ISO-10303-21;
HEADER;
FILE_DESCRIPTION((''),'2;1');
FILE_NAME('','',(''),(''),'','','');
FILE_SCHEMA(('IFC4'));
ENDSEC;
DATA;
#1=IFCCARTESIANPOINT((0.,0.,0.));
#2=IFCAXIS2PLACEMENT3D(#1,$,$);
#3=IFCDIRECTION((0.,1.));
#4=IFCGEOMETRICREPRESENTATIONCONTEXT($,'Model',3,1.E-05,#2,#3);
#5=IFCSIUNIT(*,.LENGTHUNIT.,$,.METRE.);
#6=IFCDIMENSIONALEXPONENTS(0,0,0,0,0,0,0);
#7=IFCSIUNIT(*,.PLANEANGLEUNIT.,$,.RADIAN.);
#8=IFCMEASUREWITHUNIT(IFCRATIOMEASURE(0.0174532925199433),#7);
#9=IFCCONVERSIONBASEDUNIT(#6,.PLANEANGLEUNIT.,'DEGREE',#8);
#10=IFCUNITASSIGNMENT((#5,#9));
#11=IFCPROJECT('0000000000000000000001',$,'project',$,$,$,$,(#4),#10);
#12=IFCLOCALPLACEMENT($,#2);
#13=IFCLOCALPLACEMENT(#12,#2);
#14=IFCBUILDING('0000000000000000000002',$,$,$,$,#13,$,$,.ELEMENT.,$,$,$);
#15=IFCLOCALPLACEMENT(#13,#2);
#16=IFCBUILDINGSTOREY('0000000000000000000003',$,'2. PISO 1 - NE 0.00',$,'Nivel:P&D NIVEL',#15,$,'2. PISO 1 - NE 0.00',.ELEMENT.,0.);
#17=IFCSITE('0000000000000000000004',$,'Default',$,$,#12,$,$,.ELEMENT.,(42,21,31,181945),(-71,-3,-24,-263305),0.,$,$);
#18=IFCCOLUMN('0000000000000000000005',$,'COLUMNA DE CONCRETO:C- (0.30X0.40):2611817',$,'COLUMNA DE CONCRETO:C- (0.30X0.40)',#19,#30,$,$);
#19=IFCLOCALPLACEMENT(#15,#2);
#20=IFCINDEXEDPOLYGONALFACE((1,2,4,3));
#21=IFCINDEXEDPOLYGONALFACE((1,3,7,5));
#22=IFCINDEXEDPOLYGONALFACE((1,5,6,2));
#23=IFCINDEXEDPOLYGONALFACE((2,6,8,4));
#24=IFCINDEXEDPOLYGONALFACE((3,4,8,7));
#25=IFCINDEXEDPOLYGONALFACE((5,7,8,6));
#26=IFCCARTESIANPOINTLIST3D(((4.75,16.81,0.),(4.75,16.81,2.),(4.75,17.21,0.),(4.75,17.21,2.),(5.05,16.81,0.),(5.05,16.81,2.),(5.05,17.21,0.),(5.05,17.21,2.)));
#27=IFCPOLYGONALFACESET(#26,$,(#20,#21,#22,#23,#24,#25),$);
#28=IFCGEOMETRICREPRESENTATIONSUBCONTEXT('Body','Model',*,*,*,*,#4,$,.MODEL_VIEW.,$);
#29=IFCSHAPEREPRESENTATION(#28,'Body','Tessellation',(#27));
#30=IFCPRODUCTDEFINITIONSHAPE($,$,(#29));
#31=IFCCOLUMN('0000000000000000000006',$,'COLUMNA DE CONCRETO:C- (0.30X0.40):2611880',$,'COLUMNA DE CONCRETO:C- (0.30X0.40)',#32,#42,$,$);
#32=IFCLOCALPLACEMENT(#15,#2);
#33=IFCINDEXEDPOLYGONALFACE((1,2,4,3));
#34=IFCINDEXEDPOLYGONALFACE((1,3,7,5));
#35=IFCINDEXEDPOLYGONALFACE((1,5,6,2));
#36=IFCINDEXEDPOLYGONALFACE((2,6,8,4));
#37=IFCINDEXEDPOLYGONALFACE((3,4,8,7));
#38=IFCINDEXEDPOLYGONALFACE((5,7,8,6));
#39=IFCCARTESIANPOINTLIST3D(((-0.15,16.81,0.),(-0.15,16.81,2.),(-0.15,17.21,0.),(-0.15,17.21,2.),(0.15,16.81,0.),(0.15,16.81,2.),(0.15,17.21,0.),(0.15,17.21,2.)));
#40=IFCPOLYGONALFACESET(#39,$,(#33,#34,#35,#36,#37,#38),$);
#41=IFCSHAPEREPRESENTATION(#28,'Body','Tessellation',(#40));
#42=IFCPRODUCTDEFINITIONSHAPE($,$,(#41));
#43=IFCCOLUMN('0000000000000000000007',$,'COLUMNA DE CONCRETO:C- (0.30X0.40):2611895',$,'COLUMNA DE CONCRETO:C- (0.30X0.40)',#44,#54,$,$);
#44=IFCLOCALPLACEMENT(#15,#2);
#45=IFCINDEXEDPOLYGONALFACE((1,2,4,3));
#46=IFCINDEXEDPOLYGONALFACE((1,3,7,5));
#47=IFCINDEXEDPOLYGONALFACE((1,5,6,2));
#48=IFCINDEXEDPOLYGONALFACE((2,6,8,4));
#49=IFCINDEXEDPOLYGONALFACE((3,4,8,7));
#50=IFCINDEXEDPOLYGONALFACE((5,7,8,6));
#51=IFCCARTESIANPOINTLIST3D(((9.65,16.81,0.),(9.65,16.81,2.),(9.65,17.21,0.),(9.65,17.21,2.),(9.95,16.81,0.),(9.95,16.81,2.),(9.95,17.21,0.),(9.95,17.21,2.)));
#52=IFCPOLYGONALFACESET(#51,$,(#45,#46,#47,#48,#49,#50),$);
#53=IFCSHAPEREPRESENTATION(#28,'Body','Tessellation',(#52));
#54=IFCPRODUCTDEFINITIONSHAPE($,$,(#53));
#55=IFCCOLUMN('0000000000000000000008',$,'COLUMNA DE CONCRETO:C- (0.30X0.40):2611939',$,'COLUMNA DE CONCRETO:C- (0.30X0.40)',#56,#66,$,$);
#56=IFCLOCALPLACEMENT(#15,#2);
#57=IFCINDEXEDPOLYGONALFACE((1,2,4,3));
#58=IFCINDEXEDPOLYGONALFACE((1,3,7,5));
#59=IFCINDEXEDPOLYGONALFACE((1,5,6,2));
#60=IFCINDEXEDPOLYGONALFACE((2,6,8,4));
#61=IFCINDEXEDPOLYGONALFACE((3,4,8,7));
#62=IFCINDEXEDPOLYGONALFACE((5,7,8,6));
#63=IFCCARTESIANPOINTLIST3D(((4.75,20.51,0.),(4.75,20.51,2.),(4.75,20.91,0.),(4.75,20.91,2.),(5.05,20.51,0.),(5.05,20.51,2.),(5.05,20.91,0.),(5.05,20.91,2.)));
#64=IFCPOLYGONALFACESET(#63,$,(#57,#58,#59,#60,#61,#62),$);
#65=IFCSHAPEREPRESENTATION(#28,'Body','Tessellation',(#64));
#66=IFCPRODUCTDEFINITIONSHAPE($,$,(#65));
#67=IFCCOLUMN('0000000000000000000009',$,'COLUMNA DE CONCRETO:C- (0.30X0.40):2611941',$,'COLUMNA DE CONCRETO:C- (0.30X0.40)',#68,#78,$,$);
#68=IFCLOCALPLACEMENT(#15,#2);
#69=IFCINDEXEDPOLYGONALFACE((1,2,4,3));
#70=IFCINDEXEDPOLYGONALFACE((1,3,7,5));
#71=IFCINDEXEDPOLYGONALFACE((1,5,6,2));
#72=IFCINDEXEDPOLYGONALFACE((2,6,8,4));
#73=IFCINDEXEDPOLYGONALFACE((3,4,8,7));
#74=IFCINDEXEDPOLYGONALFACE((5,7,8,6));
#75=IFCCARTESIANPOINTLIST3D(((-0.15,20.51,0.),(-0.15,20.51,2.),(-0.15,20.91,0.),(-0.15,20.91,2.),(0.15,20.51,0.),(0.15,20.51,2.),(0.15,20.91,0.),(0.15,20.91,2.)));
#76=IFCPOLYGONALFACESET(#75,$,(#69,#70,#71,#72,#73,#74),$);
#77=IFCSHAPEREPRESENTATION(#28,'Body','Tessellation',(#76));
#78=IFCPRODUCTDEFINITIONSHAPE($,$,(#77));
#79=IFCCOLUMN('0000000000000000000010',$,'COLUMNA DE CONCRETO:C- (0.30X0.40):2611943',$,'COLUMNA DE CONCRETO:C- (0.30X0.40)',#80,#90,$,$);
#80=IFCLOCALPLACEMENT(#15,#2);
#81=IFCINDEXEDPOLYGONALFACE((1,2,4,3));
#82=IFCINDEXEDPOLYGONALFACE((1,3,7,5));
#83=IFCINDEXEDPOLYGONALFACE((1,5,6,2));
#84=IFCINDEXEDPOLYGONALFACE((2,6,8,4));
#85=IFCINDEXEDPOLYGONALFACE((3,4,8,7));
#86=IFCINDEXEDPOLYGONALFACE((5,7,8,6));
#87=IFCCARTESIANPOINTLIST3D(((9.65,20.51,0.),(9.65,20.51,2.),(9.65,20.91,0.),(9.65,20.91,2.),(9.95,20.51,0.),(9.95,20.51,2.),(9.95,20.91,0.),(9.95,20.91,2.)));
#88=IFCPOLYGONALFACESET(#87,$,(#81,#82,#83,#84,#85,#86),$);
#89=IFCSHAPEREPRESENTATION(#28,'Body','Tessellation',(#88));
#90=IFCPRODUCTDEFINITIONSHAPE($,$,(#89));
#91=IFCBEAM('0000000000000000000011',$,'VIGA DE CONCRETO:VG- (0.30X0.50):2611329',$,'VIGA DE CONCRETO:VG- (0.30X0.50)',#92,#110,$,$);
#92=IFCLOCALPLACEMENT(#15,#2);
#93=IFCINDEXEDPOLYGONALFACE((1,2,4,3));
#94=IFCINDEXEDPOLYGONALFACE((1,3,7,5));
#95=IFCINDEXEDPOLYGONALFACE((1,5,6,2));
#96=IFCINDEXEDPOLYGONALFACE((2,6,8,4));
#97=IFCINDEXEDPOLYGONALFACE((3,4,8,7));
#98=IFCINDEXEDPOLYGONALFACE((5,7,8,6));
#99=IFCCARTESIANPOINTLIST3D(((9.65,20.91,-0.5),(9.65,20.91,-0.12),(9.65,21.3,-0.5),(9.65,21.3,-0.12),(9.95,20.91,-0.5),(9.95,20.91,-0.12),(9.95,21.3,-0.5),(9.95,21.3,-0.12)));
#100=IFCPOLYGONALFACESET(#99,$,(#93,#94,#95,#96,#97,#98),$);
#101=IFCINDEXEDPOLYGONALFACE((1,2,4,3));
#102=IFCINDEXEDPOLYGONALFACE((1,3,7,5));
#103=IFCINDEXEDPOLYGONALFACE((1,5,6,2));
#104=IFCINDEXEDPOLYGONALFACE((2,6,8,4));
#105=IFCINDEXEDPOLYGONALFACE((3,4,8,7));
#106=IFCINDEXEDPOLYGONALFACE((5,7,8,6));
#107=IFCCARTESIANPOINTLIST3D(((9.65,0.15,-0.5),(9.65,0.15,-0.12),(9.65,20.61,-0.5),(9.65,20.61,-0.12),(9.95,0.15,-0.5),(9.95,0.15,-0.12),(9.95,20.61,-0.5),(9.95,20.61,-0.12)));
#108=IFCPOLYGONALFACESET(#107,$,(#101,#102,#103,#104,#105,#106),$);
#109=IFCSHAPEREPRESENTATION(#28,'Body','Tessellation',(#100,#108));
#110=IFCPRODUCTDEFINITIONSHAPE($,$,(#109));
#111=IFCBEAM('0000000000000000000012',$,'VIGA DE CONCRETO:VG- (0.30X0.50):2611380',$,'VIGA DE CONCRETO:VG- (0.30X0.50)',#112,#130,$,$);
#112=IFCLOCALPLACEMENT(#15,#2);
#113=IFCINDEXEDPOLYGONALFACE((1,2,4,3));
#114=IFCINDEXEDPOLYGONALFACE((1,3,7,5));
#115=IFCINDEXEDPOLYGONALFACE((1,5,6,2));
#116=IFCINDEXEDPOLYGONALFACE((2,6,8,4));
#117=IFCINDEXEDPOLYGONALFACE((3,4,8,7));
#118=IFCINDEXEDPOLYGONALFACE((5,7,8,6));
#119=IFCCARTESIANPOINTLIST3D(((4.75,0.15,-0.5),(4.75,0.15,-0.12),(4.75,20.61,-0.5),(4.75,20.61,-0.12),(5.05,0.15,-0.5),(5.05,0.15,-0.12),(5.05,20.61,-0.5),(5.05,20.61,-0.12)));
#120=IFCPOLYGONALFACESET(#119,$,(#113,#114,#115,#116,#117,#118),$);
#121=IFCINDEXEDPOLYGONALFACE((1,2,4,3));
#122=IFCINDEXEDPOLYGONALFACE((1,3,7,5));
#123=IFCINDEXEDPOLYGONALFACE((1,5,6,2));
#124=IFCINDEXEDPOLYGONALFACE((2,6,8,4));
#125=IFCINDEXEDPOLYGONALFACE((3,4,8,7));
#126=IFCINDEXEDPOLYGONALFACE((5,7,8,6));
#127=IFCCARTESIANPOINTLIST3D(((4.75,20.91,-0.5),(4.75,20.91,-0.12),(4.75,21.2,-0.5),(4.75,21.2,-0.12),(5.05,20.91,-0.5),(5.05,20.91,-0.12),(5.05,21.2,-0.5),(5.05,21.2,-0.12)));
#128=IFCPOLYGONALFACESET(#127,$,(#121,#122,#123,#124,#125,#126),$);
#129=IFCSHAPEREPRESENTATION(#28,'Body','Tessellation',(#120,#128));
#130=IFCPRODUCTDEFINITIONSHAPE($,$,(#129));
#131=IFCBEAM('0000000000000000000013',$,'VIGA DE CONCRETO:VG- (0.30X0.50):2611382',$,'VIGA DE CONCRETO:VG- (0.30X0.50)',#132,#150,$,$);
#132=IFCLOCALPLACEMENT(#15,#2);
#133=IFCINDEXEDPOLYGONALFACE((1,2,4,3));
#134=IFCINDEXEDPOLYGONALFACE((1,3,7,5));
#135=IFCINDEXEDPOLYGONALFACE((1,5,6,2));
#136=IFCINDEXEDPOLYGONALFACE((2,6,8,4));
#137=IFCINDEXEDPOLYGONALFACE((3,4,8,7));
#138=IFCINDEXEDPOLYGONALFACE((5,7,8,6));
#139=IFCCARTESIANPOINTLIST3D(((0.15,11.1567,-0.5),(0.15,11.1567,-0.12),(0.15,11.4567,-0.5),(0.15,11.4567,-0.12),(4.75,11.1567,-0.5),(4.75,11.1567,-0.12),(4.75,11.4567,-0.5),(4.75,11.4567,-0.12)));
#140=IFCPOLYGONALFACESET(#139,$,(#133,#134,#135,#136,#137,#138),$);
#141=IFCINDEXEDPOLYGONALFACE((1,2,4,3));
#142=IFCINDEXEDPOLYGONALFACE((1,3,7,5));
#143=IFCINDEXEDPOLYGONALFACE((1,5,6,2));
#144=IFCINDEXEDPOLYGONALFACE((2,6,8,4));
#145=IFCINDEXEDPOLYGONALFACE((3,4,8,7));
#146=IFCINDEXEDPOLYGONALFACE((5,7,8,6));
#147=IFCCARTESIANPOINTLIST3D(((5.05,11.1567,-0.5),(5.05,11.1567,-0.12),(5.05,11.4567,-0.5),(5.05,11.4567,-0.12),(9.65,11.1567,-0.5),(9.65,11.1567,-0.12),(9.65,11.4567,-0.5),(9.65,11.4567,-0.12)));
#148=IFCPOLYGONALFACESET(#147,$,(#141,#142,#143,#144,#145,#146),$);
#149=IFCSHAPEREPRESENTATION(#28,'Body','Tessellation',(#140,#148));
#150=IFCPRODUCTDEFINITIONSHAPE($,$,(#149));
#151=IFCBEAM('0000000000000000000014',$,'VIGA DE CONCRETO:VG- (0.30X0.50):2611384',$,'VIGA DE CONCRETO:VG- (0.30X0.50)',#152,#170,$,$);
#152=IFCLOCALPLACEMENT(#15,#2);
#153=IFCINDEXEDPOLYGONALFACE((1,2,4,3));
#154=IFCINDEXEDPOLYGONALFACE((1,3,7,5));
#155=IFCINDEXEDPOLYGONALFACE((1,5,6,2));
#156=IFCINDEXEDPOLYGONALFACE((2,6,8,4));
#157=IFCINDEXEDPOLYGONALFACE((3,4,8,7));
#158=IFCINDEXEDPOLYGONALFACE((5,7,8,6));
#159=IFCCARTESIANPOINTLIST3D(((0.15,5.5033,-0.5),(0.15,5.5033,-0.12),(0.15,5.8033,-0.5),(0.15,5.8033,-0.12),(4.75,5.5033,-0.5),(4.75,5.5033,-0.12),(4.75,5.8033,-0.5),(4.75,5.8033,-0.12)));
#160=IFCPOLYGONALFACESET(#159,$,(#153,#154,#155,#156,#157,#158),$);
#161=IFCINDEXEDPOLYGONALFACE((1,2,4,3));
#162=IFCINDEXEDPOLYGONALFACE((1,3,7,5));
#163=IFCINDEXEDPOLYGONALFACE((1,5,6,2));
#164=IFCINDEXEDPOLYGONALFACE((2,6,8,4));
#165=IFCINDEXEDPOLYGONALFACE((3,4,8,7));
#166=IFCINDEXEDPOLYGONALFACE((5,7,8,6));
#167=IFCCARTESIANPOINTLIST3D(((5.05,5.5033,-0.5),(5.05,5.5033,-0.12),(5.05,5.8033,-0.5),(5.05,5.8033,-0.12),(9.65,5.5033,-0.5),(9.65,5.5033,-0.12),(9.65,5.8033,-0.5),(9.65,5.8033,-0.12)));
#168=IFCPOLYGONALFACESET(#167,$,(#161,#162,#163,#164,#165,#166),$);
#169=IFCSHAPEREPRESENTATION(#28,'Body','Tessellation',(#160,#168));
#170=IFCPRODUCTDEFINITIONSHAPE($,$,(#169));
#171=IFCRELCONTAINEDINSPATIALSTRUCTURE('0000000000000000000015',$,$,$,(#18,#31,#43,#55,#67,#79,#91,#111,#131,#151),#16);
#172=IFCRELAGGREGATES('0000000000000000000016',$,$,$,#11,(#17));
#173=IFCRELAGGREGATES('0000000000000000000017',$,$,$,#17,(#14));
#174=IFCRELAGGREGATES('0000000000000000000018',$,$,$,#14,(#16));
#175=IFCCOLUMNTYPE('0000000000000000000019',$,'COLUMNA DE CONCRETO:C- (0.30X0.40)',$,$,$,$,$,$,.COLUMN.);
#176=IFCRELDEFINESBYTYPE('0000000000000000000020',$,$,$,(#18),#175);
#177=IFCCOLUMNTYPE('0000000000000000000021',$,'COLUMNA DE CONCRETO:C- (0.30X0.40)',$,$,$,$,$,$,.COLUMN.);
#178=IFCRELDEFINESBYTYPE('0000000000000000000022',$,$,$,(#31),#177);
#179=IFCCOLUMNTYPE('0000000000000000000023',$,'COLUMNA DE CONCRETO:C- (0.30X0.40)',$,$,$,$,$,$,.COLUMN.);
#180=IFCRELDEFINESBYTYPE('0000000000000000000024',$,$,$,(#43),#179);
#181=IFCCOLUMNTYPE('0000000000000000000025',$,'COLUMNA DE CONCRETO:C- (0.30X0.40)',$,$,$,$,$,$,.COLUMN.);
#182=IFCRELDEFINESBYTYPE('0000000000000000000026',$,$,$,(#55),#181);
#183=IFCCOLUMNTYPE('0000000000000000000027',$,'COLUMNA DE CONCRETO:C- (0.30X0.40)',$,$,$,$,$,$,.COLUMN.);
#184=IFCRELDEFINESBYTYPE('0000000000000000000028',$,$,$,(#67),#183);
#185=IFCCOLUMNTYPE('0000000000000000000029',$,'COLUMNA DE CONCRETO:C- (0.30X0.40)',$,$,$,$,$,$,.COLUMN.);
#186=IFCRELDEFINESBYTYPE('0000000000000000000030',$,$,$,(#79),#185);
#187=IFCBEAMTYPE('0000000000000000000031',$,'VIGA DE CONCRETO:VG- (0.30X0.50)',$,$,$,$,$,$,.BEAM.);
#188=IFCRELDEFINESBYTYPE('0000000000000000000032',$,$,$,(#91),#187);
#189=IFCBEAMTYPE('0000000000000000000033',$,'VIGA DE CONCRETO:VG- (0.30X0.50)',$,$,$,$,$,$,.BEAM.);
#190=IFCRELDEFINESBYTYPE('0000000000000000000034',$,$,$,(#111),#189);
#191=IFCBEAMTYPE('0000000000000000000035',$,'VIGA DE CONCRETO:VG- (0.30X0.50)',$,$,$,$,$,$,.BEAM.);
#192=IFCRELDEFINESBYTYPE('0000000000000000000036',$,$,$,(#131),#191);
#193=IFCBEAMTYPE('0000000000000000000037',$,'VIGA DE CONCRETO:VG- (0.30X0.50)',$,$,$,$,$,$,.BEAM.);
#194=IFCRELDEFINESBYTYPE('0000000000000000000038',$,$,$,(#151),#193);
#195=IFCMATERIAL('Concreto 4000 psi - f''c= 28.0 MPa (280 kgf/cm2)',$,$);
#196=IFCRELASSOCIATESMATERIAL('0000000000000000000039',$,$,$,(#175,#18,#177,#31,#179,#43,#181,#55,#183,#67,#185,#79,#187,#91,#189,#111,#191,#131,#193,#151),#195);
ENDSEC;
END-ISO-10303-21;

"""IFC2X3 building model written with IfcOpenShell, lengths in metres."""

from ifc_helpers import new_model, entity, si_unit, converted_unit, direction, frame, frame_2d, origin, origin_2d_with_axis, place, context, subcontext, project, spatial, rectangle, extrude, source, transform, mapped, material, type_object, type_shapes, element, save


model = new_model("IFC2X3")

# Units and contexts
model_context = context("Model", 3, precision=1e-05, world=origin(), true_north=direction((0.0, 1.0)))
body_context = subcontext(model_context, "Body", "Model", "MODEL_VIEW")
ifc_project = project(units=[si_unit("LENGTHUNIT", "METRE"), converted_unit("PLANEANGLEUNIT", "DEGREE", entity("IfcRatioMeasure", 0.0174532925199433), si_unit("PLANEANGLEUNIT", "RADIAN"), dimensions=[0, 0, 0, 0, 0, 0, 0])], contexts=[model_context])

# Site, building, storey
site_placement = place(None, origin())
site = spatial("IfcSite", under=ifc_project, at=site_placement, Name="Default", CompositionType="ELEMENT", RefLatitude=(42, 21, 31, 181945), RefLongitude=(-71, -3, -24, -263305), RefElevation=0.0)
building_placement = place(site_placement, origin())
building = spatial("IfcBuilding", under=site, at=building_placement, CompositionType="ELEMENT")
storey_placement = place(building_placement, origin())
storey = spatial("IfcBuildingStorey", under=building, at=storey_placement, Name="2. PISO 1 - NE 0.00", ObjectType="Nivel:P&D NIVEL", LongName="2. PISO 1 - NE 0.00", CompositionType="ELEMENT", Elevation=0.0)

# Columns
ifc_material = material(Name="Concreto 4000 psi - f'c= 28.0 MPa (280 kgf/cm2)")
column_type_1 = type_object("IfcColumnType", Name="COLUMNA DE CONCRETO:C- (0.30X0.40)", PredefinedType="COLUMN", material=ifc_material)
shared_shape_1 = source(origin(), body_context, "Body", "SweptSolid", [
    extrude(rectangle(XDim=0.4, YDim=0.3, at=frame_2d((0.0, 0.0), x_axis=(1.0, 0.0))), frame((4.9, 17.01, 0.0), z_axis=(0.0, 0.0, 1.0), x_axis=(0.0, -1.0, 0.0)), (0.0, 0.0, 1.0), 2.0),
])
type_shapes(column_type_1, [shared_shape_1])
column_1_placement = place(storey_placement, origin())
element("IfcColumn", 1, at=column_1_placement, inside=storey, type_object=column_type_1, material=ifc_material, Name="COLUMNA DE CONCRETO:C- (0.30X0.40):2611817", ObjectType="COLUMNA DE CONCRETO:C- (0.30X0.40)", context=body_context, shape_type="MappedRepresentation", body=[
    mapped(shared_shape_1, transform((0.0, 0.0, 0.0), scale=1.0)),
])
column_type_2 = type_object("IfcColumnType", Name="COLUMNA DE CONCRETO:C- (0.30X0.40)", PredefinedType="COLUMN", material=ifc_material)
shared_shape_2 = source(origin(), body_context, "Body", "SweptSolid", [
    extrude(rectangle(XDim=0.4, YDim=0.3, at=origin_2d_with_axis()), frame((0.0, 17.01, 0.0), z_axis=(0.0, 0.0, 1.0), x_axis=(0.0, -1.0, 0.0)), (0.0, 0.0, 1.0), 2.0),
])
type_shapes(column_type_2, [shared_shape_2])
column_2_placement = place(storey_placement, origin())
element("IfcColumn", 2, at=column_2_placement, inside=storey, type_object=column_type_2, material=ifc_material, Name="COLUMNA DE CONCRETO:C- (0.30X0.40):2611880", ObjectType="COLUMNA DE CONCRETO:C- (0.30X0.40)", context=body_context, shape_type="MappedRepresentation", body=[
    mapped(shared_shape_2, transform((0.0, 0.0, 0.0), scale=1.0)),
])
column_type_3 = type_object("IfcColumnType", Name="COLUMNA DE CONCRETO:C- (0.30X0.40)", PredefinedType="COLUMN", material=ifc_material)
shared_shape_3 = source(origin(), body_context, "Body", "SweptSolid", [
    extrude(rectangle(XDim=0.4, YDim=0.3, at=frame_2d((0.0, 0.0), x_axis=(1.0, 0.0))), frame((9.8, 17.01, 0.0), z_axis=(0.0, 0.0, 1.0), x_axis=(0.0, -1.0, 0.0)), (0.0, 0.0, 1.0), 2.0),
])
type_shapes(column_type_3, [shared_shape_3])
column_3_placement = place(storey_placement, origin())
element("IfcColumn", 3, at=column_3_placement, inside=storey, type_object=column_type_3, material=ifc_material, Name="COLUMNA DE CONCRETO:C- (0.30X0.40):2611895", ObjectType="COLUMNA DE CONCRETO:C- (0.30X0.40)", context=body_context, shape_type="MappedRepresentation", body=[
    mapped(shared_shape_3, transform((0.0, 0.0, 0.0), scale=1.0)),
])
column_type_4 = type_object("IfcColumnType", Name="COLUMNA DE CONCRETO:C- (0.30X0.40)", PredefinedType="COLUMN", material=ifc_material)
shared_shape_4 = source(origin(), body_context, "Body", "SweptSolid", [
    extrude(rectangle(XDim=0.4, YDim=0.3, at=frame_2d((0.0, 0.0), x_axis=(1.0, 0.0))), frame((4.9, 20.71, 0.0), z_axis=(0.0, 0.0, 1.0), x_axis=(0.0, -1.0, 0.0)), (0.0, 0.0, 1.0), 2.0),
])
type_shapes(column_type_4, [shared_shape_4])
column_4_placement = place(storey_placement, origin())
element("IfcColumn", 4, at=column_4_placement, inside=storey, type_object=column_type_4, material=ifc_material, Name="COLUMNA DE CONCRETO:C- (0.30X0.40):2611939", ObjectType="COLUMNA DE CONCRETO:C- (0.30X0.40)", context=body_context, shape_type="MappedRepresentation", body=[
    mapped(shared_shape_4, transform((0.0, 0.0, 0.0), scale=1.0)),
])
column_type_5 = type_object("IfcColumnType", Name="COLUMNA DE CONCRETO:C- (0.30X0.40)", PredefinedType="COLUMN", material=ifc_material)
shared_shape_5 = source(origin(), body_context, "Body", "SweptSolid", [
    extrude(rectangle(XDim=0.4, YDim=0.3, at=frame_2d((0.0, 0.0), x_axis=(1.0, 0.0))), frame((0.0, 20.71, 0.0), z_axis=(0.0, 0.0, 1.0), x_axis=(0.0, -1.0, 0.0)), (0.0, 0.0, 1.0), 2.0),
])
type_shapes(column_type_5, [shared_shape_5])
column_5_placement = place(storey_placement, origin())
element("IfcColumn", 5, at=column_5_placement, inside=storey, type_object=column_type_5, material=ifc_material, Name="COLUMNA DE CONCRETO:C- (0.30X0.40):2611941", ObjectType="COLUMNA DE CONCRETO:C- (0.30X0.40)", context=body_context, shape_type="MappedRepresentation", body=[
    mapped(shared_shape_5, transform((0.0, 0.0, 0.0), scale=1.0)),
])
column_type_6 = type_object("IfcColumnType", Name="COLUMNA DE CONCRETO:C- (0.30X0.40)", PredefinedType="COLUMN", material=ifc_material)
shared_shape_6 = source(origin(), body_context, "Body", "SweptSolid", [
    extrude(rectangle(XDim=0.4, YDim=0.3, at=frame_2d((0.0, 0.0), x_axis=(1.0, 0.0))), frame((9.8, 20.71, 0.0), z_axis=(0.0, 0.0, 1.0), x_axis=(0.0, -1.0, 0.0)), (0.0, 0.0, 1.0), 2.0),
])
type_shapes(column_type_6, [shared_shape_6])
column_6_placement = place(storey_placement, origin())
element("IfcColumn", 6, at=column_6_placement, inside=storey, type_object=column_type_6, material=ifc_material, Name="COLUMNA DE CONCRETO:C- (0.30X0.40):2611943", ObjectType="COLUMNA DE CONCRETO:C- (0.30X0.40)", context=body_context, shape_type="MappedRepresentation", body=[
    mapped(shared_shape_6, transform((0.0, 0.0, 0.0), scale=1.0)),
])

# Beams
beam_type_1 = type_object("IfcBeamType", Name="VIGA DE CONCRETO:VG- (0.30X0.50)", PredefinedType="BEAM", material=ifc_material)
shared_shape_7 = source(origin(), body_context, "Body", "SweptSolid", [
    extrude(rectangle(XDim=0.38, YDim=0.3, at=frame_2d((0.0, 0.0), x_axis=(0.0, 1.0))), frame((9.8, 21.3, -0.31), z_axis=(0.0, -1.0, 0.0), x_axis=(-1.0, 0.0, 0.0)), (0.0, 0.0, 1.0), 0.39),
    extrude(rectangle(XDim=0.38, YDim=0.3, at=frame_2d((0.0, 0.0), x_axis=(0.0, 1.0))), frame((9.8, 20.61, -0.31), z_axis=(0.0, -1.0, 0.0), x_axis=(-1.0, 0.0, 0.0)), (0.0, 0.0, 1.0), 20.46),
])
type_shapes(beam_type_1, [shared_shape_7])
beam_1_placement = place(storey_placement, origin())
element("IfcBeam", 7, at=beam_1_placement, inside=storey, type_object=beam_type_1, material=ifc_material, Name="VIGA DE CONCRETO:VG- (0.30X0.50):2611329", ObjectType="VIGA DE CONCRETO:VG- (0.30X0.50)", context=body_context, shape_type="MappedRepresentation", body=[
    mapped(shared_shape_7, transform((0.0, 0.0, 0.0), scale=1.0)),
])
beam_type_2 = type_object("IfcBeamType", Name="VIGA DE CONCRETO:VG- (0.30X0.50)", PredefinedType="BEAM", material=ifc_material)
shared_shape_8 = source(origin(), body_context, "Body", "SweptSolid", [
    extrude(rectangle(XDim=0.38, YDim=0.3, at=frame_2d((0.0, 0.0), x_axis=(0.0, 1.0))), frame((4.9, 20.61, -0.31), z_axis=(0.0, -1.0, 0.0), x_axis=(-1.0, 0.0, 0.0)), (0.0, 0.0, 1.0), 20.46),
    extrude(rectangle(XDim=0.38, YDim=0.3, at=frame_2d((0.0, 0.0), x_axis=(0.0, 1.0))), frame((4.9, 21.2, -0.31), z_axis=(0.0, -1.0, 0.0), x_axis=(-1.0, 0.0, 0.0)), (0.0, 0.0, 1.0), 0.29),
])
type_shapes(beam_type_2, [shared_shape_8])
beam_2_placement = place(storey_placement, origin())
element("IfcBeam", 8, at=beam_2_placement, inside=storey, type_object=beam_type_2, material=ifc_material, Name="VIGA DE CONCRETO:VG- (0.30X0.50):2611380", ObjectType="VIGA DE CONCRETO:VG- (0.30X0.50)", context=body_context, shape_type="MappedRepresentation", body=[
    mapped(shared_shape_8, transform((0.0, 0.0, 0.0), scale=1.0)),
])
beam_type_3 = type_object("IfcBeamType", Name="VIGA DE CONCRETO:VG- (0.30X0.50)", PredefinedType="BEAM", material=ifc_material)
shared_shape_9 = source(origin(), body_context, "Body", "SweptSolid", [
    extrude(rectangle(XDim=0.38, YDim=0.3, at=frame_2d((0.0, 0.0), x_axis=(1.0, 0.0))), frame((0.15, 11.3067, -0.31), z_axis=(1.0, 0.0, 0.0), x_axis=(0.0, 0.0, -1.0)), (0.0, 0.0, 1.0), 4.6),
    extrude(rectangle(XDim=0.38, YDim=0.3, at=frame_2d((0.0, 0.0), x_axis=(1.0, 0.0))), frame((5.05, 11.3067, -0.31), z_axis=(1.0, 0.0, 0.0), x_axis=(0.0, 0.0, -1.0)), (0.0, 0.0, 1.0), 4.6),
])
type_shapes(beam_type_3, [shared_shape_9])
beam_3_placement = place(storey_placement, origin())
element("IfcBeam", 9, at=beam_3_placement, inside=storey, type_object=beam_type_3, material=ifc_material, Name="VIGA DE CONCRETO:VG- (0.30X0.50):2611382", ObjectType="VIGA DE CONCRETO:VG- (0.30X0.50)", context=body_context, shape_type="MappedRepresentation", body=[
    mapped(shared_shape_9, transform((0.0, 0.0, 0.0), scale=1.0)),
])
beam_type_4 = type_object("IfcBeamType", Name="VIGA DE CONCRETO:VG- (0.30X0.50)", PredefinedType="BEAM", material=ifc_material)
shared_shape_10 = source(origin(), body_context, "Body", "SweptSolid", [
    extrude(rectangle(XDim=0.38, YDim=0.3, at=frame_2d((0.0, 0.0), x_axis=(1.0, 0.0))), frame((0.15, 5.6533, -0.31), z_axis=(1.0, 0.0, 0.0), x_axis=(0.0, 0.0, -1.0)), (0.0, 0.0, 1.0), 4.6),
    extrude(rectangle(XDim=0.38, YDim=0.3, at=frame_2d((0.0, 0.0), x_axis=(1.0, 0.0))), frame((5.05, 5.6533, -0.31), z_axis=(1.0, 0.0, 0.0), x_axis=(0.0, 0.0, -1.0)), (0.0, 0.0, 1.0), 4.6),
])
type_shapes(beam_type_4, [shared_shape_10])
beam_4_placement = place(storey_placement, origin())
element("IfcBeam", 10, at=beam_4_placement, inside=storey, type_object=beam_type_4, material=ifc_material, Name="VIGA DE CONCRETO:VG- (0.30X0.50):2611384", ObjectType="VIGA DE CONCRETO:VG- (0.30X0.50)", context=body_context, shape_type="MappedRepresentation", body=[
    mapped(shared_shape_10, transform((0.0, 0.0, 0.0), scale=1.0)),
])

save(model, "model.ifc")
